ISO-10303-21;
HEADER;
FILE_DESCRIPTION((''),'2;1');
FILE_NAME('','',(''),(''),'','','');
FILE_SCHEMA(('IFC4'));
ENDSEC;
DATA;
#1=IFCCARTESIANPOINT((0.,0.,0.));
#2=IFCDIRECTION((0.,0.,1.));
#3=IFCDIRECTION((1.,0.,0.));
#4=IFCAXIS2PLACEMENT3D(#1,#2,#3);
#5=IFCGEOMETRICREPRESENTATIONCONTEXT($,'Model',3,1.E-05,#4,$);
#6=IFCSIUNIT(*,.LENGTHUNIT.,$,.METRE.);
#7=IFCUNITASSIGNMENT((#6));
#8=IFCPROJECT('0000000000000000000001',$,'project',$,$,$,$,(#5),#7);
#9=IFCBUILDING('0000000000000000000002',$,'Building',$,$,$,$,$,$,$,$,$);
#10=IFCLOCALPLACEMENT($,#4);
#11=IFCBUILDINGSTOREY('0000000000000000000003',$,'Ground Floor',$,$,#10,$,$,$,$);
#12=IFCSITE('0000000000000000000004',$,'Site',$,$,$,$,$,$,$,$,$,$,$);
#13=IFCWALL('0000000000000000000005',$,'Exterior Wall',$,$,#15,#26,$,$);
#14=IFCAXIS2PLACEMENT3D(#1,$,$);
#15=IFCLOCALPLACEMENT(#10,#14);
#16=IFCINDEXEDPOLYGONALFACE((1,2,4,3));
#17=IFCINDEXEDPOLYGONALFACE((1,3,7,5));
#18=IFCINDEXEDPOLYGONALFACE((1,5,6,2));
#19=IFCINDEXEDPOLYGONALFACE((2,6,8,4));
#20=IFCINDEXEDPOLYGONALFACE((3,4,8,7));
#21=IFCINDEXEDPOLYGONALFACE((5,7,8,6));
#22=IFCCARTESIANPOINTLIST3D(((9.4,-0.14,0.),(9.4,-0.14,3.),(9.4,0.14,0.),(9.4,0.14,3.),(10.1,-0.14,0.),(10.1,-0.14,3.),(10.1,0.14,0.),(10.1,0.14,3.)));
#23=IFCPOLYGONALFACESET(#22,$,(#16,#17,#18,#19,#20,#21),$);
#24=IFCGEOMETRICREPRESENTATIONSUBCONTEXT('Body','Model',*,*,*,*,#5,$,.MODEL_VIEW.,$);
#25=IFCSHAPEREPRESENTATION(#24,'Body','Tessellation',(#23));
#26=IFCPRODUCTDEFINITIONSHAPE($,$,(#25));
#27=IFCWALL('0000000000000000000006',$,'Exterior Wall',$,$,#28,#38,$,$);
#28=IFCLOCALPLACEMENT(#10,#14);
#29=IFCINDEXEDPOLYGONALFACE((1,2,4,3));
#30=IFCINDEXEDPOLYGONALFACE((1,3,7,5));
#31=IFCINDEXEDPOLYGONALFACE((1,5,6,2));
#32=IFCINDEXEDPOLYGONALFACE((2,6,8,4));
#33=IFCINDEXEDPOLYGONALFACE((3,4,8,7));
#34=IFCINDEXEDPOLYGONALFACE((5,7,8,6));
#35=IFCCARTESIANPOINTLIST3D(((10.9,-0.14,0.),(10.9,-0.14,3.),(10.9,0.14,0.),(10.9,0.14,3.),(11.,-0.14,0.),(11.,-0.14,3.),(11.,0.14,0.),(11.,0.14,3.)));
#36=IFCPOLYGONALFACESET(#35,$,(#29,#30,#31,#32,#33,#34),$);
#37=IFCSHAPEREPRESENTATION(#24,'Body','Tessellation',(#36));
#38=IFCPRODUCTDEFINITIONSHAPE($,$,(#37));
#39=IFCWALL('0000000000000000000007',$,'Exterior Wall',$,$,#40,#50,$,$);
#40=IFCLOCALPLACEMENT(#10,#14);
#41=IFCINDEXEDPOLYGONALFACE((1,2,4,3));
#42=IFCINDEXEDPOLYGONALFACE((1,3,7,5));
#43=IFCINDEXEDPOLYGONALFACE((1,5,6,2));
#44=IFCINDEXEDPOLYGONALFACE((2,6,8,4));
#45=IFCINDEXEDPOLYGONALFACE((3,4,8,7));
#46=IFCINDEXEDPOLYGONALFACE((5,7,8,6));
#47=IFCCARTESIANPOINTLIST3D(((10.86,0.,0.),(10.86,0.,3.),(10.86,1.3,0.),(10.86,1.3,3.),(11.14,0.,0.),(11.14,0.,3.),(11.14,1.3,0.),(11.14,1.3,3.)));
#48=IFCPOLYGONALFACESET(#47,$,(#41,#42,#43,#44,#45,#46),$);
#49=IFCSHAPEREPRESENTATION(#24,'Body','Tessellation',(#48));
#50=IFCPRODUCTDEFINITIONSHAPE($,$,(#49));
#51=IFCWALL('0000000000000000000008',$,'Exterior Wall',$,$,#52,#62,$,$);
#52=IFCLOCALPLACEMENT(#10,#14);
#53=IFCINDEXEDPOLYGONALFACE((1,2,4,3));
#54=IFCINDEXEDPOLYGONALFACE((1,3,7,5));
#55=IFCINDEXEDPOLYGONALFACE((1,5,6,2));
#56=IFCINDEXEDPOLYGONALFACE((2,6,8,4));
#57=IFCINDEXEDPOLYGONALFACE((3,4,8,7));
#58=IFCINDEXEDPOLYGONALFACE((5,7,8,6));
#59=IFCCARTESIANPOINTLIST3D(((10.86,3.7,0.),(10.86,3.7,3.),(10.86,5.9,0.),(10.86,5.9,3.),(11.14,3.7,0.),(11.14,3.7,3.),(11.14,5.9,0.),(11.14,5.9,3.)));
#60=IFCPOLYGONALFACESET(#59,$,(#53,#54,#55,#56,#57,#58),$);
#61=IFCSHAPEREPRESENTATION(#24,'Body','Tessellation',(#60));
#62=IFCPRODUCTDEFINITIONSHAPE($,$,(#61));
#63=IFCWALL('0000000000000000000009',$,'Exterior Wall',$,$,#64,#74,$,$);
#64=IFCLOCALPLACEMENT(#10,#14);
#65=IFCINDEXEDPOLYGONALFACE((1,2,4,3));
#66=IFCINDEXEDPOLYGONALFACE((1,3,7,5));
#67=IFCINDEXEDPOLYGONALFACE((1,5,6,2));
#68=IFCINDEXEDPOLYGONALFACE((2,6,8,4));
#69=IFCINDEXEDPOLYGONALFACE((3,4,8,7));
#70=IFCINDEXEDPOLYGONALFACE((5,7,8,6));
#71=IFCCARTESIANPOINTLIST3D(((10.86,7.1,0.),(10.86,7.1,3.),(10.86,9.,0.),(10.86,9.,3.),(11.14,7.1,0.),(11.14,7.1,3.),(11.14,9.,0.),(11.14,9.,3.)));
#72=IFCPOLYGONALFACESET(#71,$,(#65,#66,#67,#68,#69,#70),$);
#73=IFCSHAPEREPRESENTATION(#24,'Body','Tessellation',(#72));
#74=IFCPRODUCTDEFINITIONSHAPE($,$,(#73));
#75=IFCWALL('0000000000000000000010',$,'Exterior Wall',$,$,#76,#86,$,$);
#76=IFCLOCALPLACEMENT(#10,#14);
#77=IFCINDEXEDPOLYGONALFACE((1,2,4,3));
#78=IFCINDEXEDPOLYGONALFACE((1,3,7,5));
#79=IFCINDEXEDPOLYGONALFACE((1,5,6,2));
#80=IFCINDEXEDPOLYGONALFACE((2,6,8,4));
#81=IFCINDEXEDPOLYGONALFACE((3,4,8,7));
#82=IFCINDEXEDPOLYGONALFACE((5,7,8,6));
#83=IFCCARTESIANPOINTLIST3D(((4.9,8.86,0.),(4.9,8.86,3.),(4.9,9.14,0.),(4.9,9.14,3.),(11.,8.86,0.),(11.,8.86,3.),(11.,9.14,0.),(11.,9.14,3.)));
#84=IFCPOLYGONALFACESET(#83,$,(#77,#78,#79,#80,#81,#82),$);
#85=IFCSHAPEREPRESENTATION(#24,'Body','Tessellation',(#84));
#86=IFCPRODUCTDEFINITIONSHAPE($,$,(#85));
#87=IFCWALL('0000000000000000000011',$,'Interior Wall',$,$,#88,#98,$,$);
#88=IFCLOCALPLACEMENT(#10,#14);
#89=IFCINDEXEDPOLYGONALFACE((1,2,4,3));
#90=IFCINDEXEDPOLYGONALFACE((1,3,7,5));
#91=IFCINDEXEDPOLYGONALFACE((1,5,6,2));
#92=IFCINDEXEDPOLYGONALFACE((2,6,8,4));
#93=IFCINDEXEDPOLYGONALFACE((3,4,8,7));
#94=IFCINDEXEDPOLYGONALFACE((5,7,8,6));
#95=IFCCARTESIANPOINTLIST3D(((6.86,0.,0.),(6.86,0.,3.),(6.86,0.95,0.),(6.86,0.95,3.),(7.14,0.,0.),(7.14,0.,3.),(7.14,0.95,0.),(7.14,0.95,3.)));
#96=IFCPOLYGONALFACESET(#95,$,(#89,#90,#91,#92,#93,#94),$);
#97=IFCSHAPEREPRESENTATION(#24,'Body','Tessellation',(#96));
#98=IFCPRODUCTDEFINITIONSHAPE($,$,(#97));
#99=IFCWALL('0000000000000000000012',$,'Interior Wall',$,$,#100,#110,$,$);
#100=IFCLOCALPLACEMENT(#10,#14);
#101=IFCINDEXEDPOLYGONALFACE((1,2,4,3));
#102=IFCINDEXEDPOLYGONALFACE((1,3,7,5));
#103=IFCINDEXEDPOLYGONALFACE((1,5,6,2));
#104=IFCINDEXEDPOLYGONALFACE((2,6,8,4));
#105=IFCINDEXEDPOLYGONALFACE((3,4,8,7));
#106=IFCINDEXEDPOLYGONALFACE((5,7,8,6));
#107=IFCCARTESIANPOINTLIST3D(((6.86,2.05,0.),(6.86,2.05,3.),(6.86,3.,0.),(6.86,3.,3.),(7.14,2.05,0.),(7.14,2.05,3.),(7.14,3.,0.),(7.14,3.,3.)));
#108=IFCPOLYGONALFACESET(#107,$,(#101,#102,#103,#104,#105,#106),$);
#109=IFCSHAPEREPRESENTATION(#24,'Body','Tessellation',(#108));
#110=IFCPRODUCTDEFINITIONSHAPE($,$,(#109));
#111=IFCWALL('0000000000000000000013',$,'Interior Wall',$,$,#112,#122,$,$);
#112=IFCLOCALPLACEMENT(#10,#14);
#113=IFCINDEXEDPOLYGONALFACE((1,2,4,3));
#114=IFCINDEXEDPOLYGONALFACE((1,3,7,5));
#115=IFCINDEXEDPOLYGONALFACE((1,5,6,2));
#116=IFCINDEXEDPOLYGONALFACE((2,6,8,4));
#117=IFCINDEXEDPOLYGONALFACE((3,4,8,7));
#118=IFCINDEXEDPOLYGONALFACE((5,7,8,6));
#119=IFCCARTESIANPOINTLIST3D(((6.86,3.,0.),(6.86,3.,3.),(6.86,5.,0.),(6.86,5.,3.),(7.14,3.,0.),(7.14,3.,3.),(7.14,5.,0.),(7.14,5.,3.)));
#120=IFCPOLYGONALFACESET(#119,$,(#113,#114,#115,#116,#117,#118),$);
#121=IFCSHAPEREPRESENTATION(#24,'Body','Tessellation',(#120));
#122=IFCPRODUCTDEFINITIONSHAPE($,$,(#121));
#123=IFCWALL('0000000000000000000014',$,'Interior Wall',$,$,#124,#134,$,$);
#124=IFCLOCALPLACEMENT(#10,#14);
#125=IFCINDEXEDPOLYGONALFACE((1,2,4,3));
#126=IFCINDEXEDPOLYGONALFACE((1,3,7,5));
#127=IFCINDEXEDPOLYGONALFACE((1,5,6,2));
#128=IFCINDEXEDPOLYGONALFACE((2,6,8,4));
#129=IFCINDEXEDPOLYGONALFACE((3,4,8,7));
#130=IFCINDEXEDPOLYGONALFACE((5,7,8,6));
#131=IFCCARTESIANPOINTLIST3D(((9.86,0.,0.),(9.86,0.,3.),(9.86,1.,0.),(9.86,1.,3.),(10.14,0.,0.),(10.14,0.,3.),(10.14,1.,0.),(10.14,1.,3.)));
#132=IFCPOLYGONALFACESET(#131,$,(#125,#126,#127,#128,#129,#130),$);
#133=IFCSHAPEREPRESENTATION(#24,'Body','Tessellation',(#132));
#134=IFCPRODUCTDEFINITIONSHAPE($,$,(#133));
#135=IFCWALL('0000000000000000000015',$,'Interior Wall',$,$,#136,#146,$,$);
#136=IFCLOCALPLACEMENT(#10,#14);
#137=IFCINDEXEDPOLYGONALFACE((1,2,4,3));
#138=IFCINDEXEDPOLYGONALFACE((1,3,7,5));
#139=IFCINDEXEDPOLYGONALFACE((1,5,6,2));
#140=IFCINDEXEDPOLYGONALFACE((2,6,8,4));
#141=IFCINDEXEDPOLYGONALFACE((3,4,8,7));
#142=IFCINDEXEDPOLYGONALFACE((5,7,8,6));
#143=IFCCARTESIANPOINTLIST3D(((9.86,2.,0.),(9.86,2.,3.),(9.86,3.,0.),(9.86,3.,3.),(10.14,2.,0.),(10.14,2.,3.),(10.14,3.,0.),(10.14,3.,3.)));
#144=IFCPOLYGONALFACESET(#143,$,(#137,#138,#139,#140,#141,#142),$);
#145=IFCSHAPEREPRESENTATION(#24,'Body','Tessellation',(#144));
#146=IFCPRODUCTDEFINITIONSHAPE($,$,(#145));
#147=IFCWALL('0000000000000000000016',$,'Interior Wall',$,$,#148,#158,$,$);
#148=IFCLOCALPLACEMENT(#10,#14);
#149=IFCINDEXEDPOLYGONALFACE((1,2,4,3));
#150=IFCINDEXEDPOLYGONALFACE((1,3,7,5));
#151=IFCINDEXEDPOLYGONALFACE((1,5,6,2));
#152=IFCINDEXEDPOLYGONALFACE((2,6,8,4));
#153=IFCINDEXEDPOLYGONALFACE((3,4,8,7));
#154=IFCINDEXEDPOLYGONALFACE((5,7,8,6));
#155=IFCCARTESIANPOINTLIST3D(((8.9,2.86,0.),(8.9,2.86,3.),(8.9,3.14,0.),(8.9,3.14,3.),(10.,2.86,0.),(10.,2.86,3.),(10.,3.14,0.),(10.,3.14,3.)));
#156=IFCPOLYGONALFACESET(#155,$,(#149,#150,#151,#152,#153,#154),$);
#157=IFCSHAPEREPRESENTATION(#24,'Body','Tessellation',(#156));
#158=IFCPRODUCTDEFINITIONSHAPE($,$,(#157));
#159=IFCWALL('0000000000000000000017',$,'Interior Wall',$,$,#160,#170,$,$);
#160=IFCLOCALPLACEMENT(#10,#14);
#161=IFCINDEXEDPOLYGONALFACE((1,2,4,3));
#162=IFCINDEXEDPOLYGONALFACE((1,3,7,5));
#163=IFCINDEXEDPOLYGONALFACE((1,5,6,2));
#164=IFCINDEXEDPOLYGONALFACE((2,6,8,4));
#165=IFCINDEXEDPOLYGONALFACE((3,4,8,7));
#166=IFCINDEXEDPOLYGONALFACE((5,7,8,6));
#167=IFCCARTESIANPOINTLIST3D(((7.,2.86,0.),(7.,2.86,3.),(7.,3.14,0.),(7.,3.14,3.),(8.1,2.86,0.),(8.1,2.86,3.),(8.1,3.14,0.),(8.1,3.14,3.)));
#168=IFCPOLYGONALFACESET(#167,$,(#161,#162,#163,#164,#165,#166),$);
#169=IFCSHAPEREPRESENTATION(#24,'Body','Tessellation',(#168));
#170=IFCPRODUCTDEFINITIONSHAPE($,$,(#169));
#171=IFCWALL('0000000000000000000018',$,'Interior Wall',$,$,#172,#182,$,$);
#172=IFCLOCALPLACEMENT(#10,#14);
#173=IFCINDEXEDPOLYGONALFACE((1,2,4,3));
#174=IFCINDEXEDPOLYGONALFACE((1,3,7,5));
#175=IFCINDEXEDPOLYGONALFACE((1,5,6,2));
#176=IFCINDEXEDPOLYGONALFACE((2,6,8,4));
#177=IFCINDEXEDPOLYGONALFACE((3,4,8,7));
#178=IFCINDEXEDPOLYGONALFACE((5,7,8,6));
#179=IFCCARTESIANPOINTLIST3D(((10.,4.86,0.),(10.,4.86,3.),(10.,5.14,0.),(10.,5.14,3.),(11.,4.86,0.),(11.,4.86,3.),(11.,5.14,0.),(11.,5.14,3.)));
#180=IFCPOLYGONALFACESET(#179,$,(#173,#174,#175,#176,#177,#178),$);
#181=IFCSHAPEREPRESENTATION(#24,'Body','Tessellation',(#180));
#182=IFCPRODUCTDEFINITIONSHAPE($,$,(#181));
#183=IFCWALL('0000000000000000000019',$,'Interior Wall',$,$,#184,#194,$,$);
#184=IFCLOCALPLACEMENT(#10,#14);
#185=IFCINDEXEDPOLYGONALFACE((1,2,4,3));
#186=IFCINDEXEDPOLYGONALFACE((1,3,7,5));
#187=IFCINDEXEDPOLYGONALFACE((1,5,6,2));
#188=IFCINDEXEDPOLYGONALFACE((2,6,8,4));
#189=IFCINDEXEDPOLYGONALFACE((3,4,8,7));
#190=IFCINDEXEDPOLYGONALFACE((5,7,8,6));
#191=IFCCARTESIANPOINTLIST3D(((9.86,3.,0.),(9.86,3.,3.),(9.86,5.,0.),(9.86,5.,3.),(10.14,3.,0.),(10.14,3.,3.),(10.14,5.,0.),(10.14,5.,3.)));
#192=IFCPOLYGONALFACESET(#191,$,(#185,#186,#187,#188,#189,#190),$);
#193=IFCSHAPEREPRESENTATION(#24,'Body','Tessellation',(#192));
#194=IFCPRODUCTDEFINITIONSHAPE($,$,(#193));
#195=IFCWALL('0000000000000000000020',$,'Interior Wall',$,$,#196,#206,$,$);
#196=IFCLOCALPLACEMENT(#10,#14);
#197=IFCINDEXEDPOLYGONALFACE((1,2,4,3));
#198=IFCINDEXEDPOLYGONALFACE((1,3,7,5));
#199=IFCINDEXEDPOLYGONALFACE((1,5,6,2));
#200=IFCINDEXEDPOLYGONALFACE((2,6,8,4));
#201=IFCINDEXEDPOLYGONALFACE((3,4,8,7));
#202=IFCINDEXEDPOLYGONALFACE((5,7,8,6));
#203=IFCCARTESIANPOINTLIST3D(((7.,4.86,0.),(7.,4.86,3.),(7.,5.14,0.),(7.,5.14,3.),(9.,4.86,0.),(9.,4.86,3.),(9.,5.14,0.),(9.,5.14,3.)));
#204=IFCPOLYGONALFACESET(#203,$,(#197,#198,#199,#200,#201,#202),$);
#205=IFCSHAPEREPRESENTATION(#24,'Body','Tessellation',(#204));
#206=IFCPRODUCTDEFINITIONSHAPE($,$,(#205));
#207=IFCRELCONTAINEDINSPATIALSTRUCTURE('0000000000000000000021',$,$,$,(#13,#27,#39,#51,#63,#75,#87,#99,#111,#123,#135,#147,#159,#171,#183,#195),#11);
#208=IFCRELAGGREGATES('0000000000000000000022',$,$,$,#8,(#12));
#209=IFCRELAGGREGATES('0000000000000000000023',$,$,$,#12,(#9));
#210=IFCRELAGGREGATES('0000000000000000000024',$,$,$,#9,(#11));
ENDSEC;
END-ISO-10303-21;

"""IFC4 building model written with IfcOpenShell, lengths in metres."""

from ifc_helpers import new_model, si_unit, frame, origin_with_axes, place, context, subcontext, project, spatial, indexed_curve, outline, extrude, element, save


model = new_model("IFC4")

# Units and contexts
model_context = context("Model", 3, precision=1e-05, world=origin_with_axes())
body_context = subcontext(model_context, "Body", "Model", "MODEL_VIEW")
ifc_project = project(units=[si_unit("LENGTHUNIT", "METRE")], contexts=[model_context])

# Site, building, storey
site = spatial("IfcSite", under=ifc_project, Name="Site")
building = spatial("IfcBuilding", under=site, Name="Building")
storey_placement = place(None, origin_with_axes())
storey = spatial("IfcBuildingStorey", under=building, at=storey_placement, Name="Ground Floor")

# Walls
wall_1_placement = place(storey_placement, frame((9.4, 0.0, 0.0), z_axis=(0.0, 0.0, 1.0), x_axis=(1.0, 0.0, 0.0)))
element("IfcWall", 1, at=wall_1_placement, inside=storey, Name="Exterior Wall", context=body_context, shape_type="SweptSolid", body=[
    extrude(outline(indexed_curve([(0.0, 0.0), (0.0, 0.28), (0.7, 0.28), (0.7, 0.0), (0.0, 0.0)], self_intersect=False)), frame((0.0, -0.14, 0.0), z_axis=(0.0, 0.0, 1.0), x_axis=(1.0, 0.0, 0.0)), (0.0, 0.0, 1.0), 3.0),
])
wall_2_placement = place(storey_placement, frame((10.9, 0.0, 0.0), z_axis=(0.0, 0.0, 1.0), x_axis=(1.0, 0.0, 0.0)))
element("IfcWall", 2, at=wall_2_placement, inside=storey, Name="Exterior Wall", context=body_context, shape_type="SweptSolid", body=[
    extrude(outline(indexed_curve([(0.0, 0.0), (0.0, 0.28), (0.1, 0.28), (0.1, 0.0), (0.0, 0.0)], self_intersect=False)), frame((0.0, -0.14, 0.0), z_axis=(0.0, 0.0, 1.0), x_axis=(1.0, 0.0, 0.0)), (0.0, 0.0, 1.0), 3.0),
])
wall_3_placement = place(storey_placement, frame((11.0, 0.0, 0.0), z_axis=(0.0, 0.0, 1.0), x_axis=(0.0, 1.0, 0.0)))
element("IfcWall", 3, at=wall_3_placement, inside=storey, Name="Exterior Wall", context=body_context, shape_type="SweptSolid", body=[
    extrude(outline(indexed_curve([(0.0, 0.0), (0.0, 0.28), (1.3, 0.28), (1.3, 0.0), (0.0, 0.0)], self_intersect=False)), frame((0.0, -0.14, 0.0), z_axis=(0.0, 0.0, 1.0), x_axis=(1.0, 0.0, 0.0)), (0.0, 0.0, 1.0), 3.0),
])
wall_4_placement = place(storey_placement, frame((11.0, 3.7, 0.0), z_axis=(0.0, 0.0, 1.0), x_axis=(0.0, 1.0, 0.0)))
element("IfcWall", 4, at=wall_4_placement, inside=storey, Name="Exterior Wall", context=body_context, shape_type="SweptSolid", body=[
    extrude(outline(indexed_curve([(0.0, 0.0), (0.0, 0.28), (2.2, 0.28), (2.2, 0.0), (0.0, 0.0)], self_intersect=False)), frame((0.0, -0.14, 0.0), z_axis=(0.0, 0.0, 1.0), x_axis=(1.0, 0.0, 0.0)), (0.0, 0.0, 1.0), 3.0),
])
wall_5_placement = place(storey_placement, frame((11.0, 7.1, 0.0), z_axis=(0.0, 0.0, 1.0), x_axis=(0.0, 1.0, 0.0)))
element("IfcWall", 5, at=wall_5_placement, inside=storey, Name="Exterior Wall", context=body_context, shape_type="SweptSolid", body=[
    extrude(outline(indexed_curve([(0.0, 0.0), (0.0, 0.28), (1.9, 0.28), (1.9, 0.0), (0.0, 0.0)], self_intersect=False)), frame((0.0, -0.14, 0.0), z_axis=(0.0, 0.0, 1.0), x_axis=(1.0, 0.0, 0.0)), (0.0, 0.0, 1.0), 3.0),
])
wall_6_placement = place(storey_placement, frame((11.0, 9.0, 0.0), z_axis=(0.0, 0.0, 1.0), x_axis=(-1.0, 0.0, 0.0)))
element("IfcWall", 6, at=wall_6_placement, inside=storey, Name="Exterior Wall", context=body_context, shape_type="SweptSolid", body=[
    extrude(outline(indexed_curve([(0.0, 0.0), (0.0, 0.28), (6.1, 0.28), (6.1, 0.0), (0.0, 0.0)], self_intersect=False)), frame((0.0, -0.14, 0.0), z_axis=(0.0, 0.0, 1.0), x_axis=(1.0, 0.0, 0.0)), (0.0, 0.0, 1.0), 3.0),
])
wall_7_placement = place(storey_placement, frame((7.0, 0.0, 0.0), z_axis=(0.0, 0.0, 1.0), x_axis=(0.0, 1.0, 0.0)))
element("IfcWall", 7, at=wall_7_placement, inside=storey, Name="Interior Wall", context=body_context, shape_type="SweptSolid", body=[
    extrude(outline(indexed_curve([(0.0, 0.0), (0.0, 0.28), (0.95, 0.28), (0.95, 0.0), (0.0, 0.0)], self_intersect=False)), frame((0.0, -0.14, 0.0), z_axis=(0.0, 0.0, 1.0), x_axis=(1.0, 0.0, 0.0)), (0.0, 0.0, 1.0), 3.0),
])
wall_8_placement = place(storey_placement, frame((7.0, 2.05, 0.0), z_axis=(0.0, 0.0, 1.0), x_axis=(0.0, 1.0, 0.0)))
element("IfcWall", 8, at=wall_8_placement, inside=storey, Name="Interior Wall", context=body_context, shape_type="SweptSolid", body=[
    extrude(outline(indexed_curve([(0.0, 0.0), (0.0, 0.28), (0.95, 0.28), (0.95, 0.0), (0.0, 0.0)], self_intersect=False)), frame((0.0, -0.14, 0.0), z_axis=(0.0, 0.0, 1.0), x_axis=(1.0, 0.0, 0.0)), (0.0, 0.0, 1.0), 3.0),
])
wall_9_placement = place(storey_placement, frame((7.0, 3.0, 0.0), z_axis=(0.0, 0.0, 1.0), x_axis=(0.0, 1.0, 0.0)))
element("IfcWall", 9, at=wall_9_placement, inside=storey, Name="Interior Wall", context=body_context, shape_type="SweptSolid", body=[
    extrude(outline(indexed_curve([(0.0, 0.0), (0.0, 0.28), (2.0, 0.28), (2.0, 0.0), (0.0, 0.0)], self_intersect=False)), frame((0.0, -0.14, 0.0), z_axis=(0.0, 0.0, 1.0), x_axis=(1.0, 0.0, 0.0)), (0.0, 0.0, 1.0), 3.0),
])
for number, where, z_axis, x_axis, name in (
    (10, (10.0, 0.0, 0.0), (0.0, 0.0, 1.0), (0.0, 1.0, 0.0), "Interior Wall"),
    (11, (10.0, 2.0, 0.0), (0.0, 0.0, 1.0), (0.0, 1.0, 0.0), "Interior Wall"),
):
    element("IfcWall", number, at=place(storey_placement, frame(where, z_axis=z_axis, x_axis=x_axis)), inside=storey, Name=name, context=body_context, shape_type="SweptSolid", body=[
        extrude(outline(indexed_curve([(0.0, 0.0), (0.0, 0.28), (1.0, 0.28), (1.0, 0.0), (0.0, 0.0)], self_intersect=False)), frame((0.0, -0.14, 0.0), z_axis=(0.0, 0.0, 1.0), x_axis=(1.0, 0.0, 0.0)), (0.0, 0.0, 1.0), 3.0),
    ])
for number, where, z_axis, x_axis, name in (
    (12, (10.0, 3.0, 0.0), (0.0, 0.0, 1.0), (-1.0, 0.0, 0.0), "Interior Wall"),
    (13, (8.1, 3.0, 0.0), (0.0, 0.0, 1.0), (-1.0, 0.0, 0.0), "Interior Wall"),
):
    element("IfcWall", number, at=place(storey_placement, frame(where, z_axis=z_axis, x_axis=x_axis)), inside=storey, Name=name, context=body_context, shape_type="SweptSolid", body=[
        extrude(outline(indexed_curve([(0.0, 0.0), (0.0, 0.28), (1.1, 0.28), (1.1, 0.0), (0.0, 0.0)], self_intersect=False)), frame((0.0, -0.14, 0.0), z_axis=(0.0, 0.0, 1.0), x_axis=(1.0, 0.0, 0.0)), (0.0, 0.0, 1.0), 3.0),
    ])
wall_10_placement = place(storey_placement, frame((11.0, 5.0, 0.0), z_axis=(0.0, 0.0, 1.0), x_axis=(-1.0, 0.0, 0.0)))
element("IfcWall", 14, at=wall_10_placement, inside=storey, Name="Interior Wall", context=body_context, shape_type="SweptSolid", body=[
    extrude(outline(indexed_curve([(0.0, 0.0), (0.0, 0.28), (1.0, 0.28), (1.0, 0.0), (0.0, 0.0)], self_intersect=False)), frame((0.0, -0.14, 0.0), z_axis=(0.0, 0.0, 1.0), x_axis=(1.0, 0.0, 0.0)), (0.0, 0.0, 1.0), 3.0),
])
for number, where, z_axis, x_axis, name in (
    (15, (10.0, 5.0, 0.0), (0.0, 0.0, 1.0), (0.0, -1.0, 0.0), "Interior Wall"),
    (16, (9.0, 5.0, 0.0), (0.0, 0.0, 1.0), (-1.0, 0.0, 0.0), "Interior Wall"),
):
    element("IfcWall", number, at=place(storey_placement, frame(where, z_axis=z_axis, x_axis=x_axis)), inside=storey, Name=name, context=body_context, shape_type="SweptSolid", body=[
        extrude(outline(indexed_curve([(0.0, 0.0), (0.0, 0.28), (2.0, 0.28), (2.0, 0.0), (0.0, 0.0)], self_intersect=False)), frame((0.0, -0.14, 0.0), z_axis=(0.0, 0.0, 1.0), x_axis=(1.0, 0.0, 0.0)), (0.0, 0.0, 1.0), 3.0),
    ])

save(model, "model.ifc")
